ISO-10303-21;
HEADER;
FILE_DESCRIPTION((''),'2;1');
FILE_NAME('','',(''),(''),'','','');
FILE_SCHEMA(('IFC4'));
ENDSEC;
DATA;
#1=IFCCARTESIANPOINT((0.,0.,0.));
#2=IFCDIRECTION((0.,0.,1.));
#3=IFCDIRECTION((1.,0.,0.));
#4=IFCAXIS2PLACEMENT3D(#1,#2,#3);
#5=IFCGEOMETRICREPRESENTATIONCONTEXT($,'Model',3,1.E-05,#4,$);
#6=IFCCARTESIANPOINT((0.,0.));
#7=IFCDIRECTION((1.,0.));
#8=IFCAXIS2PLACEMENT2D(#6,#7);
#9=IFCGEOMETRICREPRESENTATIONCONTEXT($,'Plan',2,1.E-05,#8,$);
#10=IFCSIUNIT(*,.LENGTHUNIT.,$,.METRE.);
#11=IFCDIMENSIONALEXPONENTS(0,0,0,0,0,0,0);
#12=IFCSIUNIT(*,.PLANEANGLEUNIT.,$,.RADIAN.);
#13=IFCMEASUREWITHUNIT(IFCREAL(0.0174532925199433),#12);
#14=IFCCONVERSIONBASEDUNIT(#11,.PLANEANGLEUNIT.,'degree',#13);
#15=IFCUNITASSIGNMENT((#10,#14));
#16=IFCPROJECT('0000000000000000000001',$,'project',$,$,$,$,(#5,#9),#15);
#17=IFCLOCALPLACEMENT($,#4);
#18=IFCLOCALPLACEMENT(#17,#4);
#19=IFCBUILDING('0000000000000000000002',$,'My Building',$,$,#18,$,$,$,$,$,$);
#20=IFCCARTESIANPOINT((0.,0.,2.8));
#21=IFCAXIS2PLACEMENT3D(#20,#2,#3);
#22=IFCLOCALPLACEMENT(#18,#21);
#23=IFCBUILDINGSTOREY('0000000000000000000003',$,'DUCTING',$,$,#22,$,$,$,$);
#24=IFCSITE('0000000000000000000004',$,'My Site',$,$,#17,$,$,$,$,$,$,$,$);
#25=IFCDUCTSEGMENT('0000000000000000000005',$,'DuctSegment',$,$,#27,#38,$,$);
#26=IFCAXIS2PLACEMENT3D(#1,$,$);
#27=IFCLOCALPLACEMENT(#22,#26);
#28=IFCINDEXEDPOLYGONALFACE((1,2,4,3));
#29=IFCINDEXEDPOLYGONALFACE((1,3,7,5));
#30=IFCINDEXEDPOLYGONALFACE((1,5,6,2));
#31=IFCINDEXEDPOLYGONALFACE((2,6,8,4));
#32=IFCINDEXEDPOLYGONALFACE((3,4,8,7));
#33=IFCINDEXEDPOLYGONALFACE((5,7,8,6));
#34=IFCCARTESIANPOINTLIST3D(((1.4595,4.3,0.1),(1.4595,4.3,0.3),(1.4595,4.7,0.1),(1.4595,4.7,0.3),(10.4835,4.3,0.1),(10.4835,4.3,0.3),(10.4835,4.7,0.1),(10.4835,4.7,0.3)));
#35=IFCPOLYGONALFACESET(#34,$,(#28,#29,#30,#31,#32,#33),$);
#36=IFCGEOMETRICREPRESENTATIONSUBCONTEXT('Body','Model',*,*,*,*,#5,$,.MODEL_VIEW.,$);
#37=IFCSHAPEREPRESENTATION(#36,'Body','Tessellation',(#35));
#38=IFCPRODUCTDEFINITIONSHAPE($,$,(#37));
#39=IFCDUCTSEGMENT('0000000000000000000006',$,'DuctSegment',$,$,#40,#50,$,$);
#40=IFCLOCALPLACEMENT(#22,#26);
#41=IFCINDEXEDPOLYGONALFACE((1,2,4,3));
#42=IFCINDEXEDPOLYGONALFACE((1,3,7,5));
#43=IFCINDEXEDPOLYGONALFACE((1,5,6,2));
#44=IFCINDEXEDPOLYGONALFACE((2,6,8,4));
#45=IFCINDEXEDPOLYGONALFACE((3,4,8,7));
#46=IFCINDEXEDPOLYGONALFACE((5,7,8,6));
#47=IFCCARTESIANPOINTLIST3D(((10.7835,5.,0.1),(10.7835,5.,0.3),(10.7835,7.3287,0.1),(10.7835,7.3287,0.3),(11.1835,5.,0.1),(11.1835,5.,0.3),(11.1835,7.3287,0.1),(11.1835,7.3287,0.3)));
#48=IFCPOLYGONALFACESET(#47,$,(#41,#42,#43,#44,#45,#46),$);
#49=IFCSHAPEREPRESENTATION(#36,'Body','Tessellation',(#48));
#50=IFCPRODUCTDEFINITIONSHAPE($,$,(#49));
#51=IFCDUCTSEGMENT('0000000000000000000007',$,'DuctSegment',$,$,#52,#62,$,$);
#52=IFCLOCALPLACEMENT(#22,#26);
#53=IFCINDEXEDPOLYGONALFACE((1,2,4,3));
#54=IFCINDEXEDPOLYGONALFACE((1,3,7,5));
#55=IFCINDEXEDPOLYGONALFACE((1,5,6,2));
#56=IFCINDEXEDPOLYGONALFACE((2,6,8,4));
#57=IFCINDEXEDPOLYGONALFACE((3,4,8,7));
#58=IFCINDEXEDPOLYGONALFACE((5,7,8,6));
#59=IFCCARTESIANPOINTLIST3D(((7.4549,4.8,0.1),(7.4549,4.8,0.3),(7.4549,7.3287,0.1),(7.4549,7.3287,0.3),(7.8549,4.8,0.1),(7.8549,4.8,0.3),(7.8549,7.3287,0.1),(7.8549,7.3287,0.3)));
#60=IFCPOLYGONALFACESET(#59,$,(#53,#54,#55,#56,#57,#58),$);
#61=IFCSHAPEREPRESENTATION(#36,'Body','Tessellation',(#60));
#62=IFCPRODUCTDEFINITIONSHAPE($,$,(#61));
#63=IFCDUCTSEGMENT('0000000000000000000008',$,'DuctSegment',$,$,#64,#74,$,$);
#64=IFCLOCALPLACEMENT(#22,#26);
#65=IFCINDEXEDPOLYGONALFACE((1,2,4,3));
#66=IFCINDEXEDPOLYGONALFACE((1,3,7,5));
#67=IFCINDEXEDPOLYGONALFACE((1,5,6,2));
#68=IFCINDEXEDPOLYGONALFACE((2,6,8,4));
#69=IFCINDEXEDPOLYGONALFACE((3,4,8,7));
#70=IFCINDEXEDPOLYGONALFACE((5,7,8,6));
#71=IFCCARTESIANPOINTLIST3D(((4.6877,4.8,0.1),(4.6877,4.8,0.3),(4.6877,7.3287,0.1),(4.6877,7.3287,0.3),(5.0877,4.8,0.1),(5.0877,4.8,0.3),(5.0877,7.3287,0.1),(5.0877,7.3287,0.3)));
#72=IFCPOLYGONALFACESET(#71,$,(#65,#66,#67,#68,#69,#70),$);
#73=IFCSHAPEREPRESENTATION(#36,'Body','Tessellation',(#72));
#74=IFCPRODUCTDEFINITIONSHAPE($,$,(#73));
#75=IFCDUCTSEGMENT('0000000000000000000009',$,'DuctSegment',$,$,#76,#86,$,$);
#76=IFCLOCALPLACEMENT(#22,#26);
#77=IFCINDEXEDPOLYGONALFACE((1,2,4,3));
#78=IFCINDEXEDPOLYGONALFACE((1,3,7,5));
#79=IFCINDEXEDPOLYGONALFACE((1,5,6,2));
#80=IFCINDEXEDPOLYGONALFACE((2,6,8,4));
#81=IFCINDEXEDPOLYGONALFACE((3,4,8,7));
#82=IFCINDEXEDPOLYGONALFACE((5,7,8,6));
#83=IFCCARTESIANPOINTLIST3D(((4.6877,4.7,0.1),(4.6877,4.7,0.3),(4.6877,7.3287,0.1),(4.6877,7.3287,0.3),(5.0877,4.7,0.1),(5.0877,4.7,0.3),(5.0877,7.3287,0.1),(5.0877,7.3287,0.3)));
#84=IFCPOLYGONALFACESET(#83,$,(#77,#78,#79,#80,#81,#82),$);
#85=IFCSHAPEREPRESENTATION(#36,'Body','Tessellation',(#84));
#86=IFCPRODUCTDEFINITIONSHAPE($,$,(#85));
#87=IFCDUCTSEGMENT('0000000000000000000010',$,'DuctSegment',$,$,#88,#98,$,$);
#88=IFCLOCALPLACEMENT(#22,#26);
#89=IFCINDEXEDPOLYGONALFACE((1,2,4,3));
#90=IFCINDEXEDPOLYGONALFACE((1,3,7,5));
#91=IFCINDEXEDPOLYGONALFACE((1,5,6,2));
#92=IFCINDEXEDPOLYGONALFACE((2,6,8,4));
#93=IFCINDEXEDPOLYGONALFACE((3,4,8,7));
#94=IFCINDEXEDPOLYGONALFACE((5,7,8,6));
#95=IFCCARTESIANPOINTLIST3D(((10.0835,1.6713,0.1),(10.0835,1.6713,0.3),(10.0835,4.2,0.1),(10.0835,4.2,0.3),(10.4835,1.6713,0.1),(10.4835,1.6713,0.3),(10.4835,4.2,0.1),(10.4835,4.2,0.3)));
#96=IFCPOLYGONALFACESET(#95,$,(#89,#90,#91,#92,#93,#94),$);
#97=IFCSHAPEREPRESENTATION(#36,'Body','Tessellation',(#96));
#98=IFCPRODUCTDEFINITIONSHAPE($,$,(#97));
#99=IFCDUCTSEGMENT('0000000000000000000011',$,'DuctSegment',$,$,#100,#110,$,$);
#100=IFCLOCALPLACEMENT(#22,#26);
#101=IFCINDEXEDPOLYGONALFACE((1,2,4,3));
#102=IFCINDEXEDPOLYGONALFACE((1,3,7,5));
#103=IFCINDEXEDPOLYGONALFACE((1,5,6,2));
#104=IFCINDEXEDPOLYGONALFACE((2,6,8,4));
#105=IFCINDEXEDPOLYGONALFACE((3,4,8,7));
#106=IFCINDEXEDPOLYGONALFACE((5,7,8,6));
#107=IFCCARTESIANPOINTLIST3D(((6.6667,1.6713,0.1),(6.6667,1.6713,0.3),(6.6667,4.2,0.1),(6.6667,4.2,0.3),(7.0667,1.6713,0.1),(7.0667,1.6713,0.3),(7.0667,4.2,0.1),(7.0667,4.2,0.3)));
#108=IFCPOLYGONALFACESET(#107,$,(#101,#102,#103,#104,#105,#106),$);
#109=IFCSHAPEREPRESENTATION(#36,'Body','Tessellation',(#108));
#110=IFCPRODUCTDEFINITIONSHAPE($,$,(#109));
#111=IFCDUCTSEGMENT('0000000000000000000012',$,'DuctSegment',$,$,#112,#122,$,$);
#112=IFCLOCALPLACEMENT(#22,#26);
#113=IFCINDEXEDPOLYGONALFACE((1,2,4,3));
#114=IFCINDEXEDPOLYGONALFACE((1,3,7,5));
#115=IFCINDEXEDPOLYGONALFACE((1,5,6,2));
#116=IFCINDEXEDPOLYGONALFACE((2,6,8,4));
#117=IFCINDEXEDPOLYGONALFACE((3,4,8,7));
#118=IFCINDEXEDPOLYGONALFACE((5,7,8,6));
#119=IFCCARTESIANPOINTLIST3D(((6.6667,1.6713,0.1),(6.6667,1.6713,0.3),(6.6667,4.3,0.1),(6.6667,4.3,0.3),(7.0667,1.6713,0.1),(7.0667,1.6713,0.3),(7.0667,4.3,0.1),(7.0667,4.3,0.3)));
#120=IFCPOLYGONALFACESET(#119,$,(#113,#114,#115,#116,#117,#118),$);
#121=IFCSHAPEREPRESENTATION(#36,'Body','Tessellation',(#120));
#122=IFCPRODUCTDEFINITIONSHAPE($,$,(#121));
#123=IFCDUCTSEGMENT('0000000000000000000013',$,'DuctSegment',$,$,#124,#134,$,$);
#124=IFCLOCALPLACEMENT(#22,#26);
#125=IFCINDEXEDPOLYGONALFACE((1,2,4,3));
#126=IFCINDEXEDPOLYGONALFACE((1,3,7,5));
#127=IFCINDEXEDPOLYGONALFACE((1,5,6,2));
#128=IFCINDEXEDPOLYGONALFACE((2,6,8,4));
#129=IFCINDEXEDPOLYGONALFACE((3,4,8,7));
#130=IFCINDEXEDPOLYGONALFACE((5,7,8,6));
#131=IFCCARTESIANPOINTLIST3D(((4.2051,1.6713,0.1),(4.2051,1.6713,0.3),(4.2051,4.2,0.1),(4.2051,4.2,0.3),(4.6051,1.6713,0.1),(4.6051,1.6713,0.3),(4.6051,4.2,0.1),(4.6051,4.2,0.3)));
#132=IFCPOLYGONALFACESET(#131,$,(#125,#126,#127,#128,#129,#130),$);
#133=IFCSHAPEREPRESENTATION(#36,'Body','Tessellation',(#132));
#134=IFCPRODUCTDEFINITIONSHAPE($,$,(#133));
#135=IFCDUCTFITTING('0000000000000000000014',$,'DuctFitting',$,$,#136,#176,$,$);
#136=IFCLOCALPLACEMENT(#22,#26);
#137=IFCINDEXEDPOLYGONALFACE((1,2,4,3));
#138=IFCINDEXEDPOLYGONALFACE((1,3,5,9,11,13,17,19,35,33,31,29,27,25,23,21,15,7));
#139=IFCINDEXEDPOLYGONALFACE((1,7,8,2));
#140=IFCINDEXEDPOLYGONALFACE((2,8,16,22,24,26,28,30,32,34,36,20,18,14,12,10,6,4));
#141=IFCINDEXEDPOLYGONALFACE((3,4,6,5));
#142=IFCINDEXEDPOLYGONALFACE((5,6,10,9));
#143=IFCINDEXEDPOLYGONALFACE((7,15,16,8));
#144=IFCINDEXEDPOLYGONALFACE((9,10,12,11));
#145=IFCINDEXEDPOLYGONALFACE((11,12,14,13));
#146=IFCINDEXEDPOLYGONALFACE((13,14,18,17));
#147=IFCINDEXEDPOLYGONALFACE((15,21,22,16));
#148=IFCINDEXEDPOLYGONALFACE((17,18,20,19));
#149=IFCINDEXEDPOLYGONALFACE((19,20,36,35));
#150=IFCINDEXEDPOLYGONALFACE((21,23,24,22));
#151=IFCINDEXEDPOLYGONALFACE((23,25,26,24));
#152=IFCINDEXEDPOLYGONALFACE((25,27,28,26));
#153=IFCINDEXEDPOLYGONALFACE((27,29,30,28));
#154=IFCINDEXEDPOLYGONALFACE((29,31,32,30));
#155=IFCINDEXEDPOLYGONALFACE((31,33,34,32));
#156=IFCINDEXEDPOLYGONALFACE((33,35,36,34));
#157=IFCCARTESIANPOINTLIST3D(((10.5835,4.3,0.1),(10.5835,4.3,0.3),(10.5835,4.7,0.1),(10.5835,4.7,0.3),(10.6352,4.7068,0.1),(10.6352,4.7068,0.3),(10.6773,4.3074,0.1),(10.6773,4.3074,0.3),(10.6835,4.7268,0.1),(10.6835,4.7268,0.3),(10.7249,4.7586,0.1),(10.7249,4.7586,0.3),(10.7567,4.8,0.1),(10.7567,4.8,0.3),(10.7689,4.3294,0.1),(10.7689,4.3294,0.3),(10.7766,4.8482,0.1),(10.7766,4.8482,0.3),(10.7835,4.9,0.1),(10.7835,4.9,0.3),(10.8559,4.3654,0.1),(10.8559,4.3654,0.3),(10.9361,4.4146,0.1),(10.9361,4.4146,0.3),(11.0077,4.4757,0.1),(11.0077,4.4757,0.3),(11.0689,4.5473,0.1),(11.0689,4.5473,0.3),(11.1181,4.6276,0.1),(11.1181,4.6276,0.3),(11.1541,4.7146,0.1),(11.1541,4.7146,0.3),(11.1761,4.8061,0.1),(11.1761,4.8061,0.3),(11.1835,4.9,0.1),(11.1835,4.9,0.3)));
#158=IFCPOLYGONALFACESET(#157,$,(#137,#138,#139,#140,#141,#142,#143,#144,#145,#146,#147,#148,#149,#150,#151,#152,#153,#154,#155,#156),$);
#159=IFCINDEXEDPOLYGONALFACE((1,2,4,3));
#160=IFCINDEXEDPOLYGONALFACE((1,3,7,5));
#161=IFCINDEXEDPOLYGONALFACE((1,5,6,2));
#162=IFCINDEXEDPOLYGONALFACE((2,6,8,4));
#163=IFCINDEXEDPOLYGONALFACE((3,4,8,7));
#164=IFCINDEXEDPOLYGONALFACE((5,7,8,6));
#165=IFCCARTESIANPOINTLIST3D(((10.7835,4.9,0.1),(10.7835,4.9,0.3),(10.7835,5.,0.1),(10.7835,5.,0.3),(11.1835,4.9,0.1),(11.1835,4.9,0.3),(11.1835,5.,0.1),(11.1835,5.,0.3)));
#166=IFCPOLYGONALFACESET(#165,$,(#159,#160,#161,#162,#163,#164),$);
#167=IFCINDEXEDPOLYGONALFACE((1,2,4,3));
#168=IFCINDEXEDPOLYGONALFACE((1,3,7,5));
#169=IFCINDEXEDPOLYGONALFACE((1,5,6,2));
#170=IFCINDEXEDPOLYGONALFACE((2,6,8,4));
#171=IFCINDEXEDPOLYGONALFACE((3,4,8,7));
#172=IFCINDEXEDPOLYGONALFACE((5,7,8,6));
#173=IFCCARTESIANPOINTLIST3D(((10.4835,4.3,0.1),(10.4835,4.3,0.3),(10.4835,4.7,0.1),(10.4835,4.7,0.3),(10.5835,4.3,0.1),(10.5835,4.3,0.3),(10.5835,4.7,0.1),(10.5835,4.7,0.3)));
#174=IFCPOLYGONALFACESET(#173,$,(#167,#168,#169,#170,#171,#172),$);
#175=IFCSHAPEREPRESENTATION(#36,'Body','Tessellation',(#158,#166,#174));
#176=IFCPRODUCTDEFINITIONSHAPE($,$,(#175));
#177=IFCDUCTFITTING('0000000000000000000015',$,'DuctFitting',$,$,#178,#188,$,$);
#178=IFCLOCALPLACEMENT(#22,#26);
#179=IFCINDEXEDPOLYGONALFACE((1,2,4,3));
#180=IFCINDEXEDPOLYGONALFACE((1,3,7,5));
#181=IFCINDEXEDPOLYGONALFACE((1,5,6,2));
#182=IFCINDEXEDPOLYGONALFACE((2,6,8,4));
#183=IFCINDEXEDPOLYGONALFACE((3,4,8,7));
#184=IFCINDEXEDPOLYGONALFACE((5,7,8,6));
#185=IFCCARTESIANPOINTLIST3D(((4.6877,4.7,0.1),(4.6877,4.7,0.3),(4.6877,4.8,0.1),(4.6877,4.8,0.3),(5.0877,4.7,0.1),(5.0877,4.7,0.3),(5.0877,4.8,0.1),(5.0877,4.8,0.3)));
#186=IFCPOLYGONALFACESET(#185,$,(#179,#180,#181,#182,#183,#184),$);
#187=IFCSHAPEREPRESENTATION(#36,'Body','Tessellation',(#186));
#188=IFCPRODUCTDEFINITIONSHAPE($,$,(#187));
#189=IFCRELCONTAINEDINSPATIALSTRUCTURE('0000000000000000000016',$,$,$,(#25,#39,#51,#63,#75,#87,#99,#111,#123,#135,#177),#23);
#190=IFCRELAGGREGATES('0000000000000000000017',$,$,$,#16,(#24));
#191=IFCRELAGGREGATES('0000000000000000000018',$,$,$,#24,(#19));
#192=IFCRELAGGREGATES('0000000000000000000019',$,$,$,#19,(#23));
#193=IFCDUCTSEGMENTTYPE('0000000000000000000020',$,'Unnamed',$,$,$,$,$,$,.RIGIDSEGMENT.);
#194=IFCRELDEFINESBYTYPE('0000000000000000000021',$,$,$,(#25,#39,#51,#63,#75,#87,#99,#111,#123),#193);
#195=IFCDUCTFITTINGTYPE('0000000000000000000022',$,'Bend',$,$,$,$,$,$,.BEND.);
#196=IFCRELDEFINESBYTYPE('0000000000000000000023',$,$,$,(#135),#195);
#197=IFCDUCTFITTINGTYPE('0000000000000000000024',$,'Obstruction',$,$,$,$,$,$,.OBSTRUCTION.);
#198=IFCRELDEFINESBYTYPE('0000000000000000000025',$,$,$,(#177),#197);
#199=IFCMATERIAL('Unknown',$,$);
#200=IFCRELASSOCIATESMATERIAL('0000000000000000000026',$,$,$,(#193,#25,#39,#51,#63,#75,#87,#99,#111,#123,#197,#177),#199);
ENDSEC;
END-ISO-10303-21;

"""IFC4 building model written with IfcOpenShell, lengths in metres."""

from ifc_helpers import new_model, entity, si_unit, converted_unit, frame, origin_with_axes, origin_2d_with_axis, place, context, subcontext, project, spatial, line, arc, indexed_curve, rectangle, outline, extrude, source, transform, mapped, material, material_profile, profile_set, profile_usage, type_object, type_shapes, element, save


model = new_model("IFC4")

# Units and contexts
model_context = context("Model", 3, precision=1e-05, world=origin_with_axes())
plan_context = context("Plan", 2, precision=1e-05, world=origin_2d_with_axis())
body_context = subcontext(model_context, "Body", "Model", "MODEL_VIEW")
ifc_project = project(units=[si_unit("LENGTHUNIT", "METRE"), converted_unit("PLANEANGLEUNIT", "degree", entity("IfcReal", 0.0174532925199433), si_unit("PLANEANGLEUNIT", "RADIAN"), dimensions=[0, 0, 0, 0, 0, 0, 0])], contexts=[model_context, plan_context])

# Site, building, storey
site_placement = place(None, origin_with_axes())
site = spatial("IfcSite", under=ifc_project, at=site_placement, Name="My Site")
building_placement = place(site_placement, origin_with_axes())
building = spatial("IfcBuilding", under=site, at=building_placement, Name="My Building")
storey_placement = place(building_placement, frame((0.0, 0.0, 2.8), z_axis=(0.0, 0.0, 1.0), x_axis=(1.0, 0.0, 0.0)))
storey = spatial("IfcBuildingStorey", under=building, at=storey_placement, Name="DUCTING")

# Duct segments
ifc_material = material(Name="Unknown")
ifc_material_profile_1 = material_profile(ifc_material, rectangle(XDim=0.4, YDim=0.2))
ifc_profile_set_1 = profile_set([ifc_material_profile_1])
ifc_profile_usage_1 = profile_usage(ifc_profile_set_1, cardinal=5)
duct_segment_type = type_object("IfcDuctSegmentType", Name="Unnamed", PredefinedType="RIGIDSEGMENT", material=ifc_profile_set_1)
duct_segment_1_placement = place(storey_placement, frame((1.4595, 4.5, 0.2), z_axis=(1.0, 0.0, 0.0), x_axis=(0.0, 1.0, 0.0)))
element("IfcDuctSegment", 1, at=duct_segment_1_placement, inside=storey, type_object=duct_segment_type, material=ifc_profile_usage_1, Name="DuctSegment", context=body_context, shape_type="SweptSolid", body=[
    extrude(rectangle(XDim=0.4, YDim=0.2), origin_with_axes(), (0.0, 0.0, 1.0), 9.024),
])
ifc_profile_usage_2 = profile_usage(ifc_profile_set_1, cardinal=5)
duct_segment_2_placement = place(storey_placement, frame((10.9835, 5.0, 0.2), z_axis=(0.0, 1.0, 0.0), x_axis=(-1.0, 0.0, 0.0)))
element("IfcDuctSegment", 2, at=duct_segment_2_placement, inside=storey, type_object=duct_segment_type, material=ifc_profile_usage_2, Name="DuctSegment", context=body_context, shape_type="SweptSolid", body=[
    extrude(rectangle(XDim=0.4, YDim=0.2), origin_with_axes(), (0.0, 0.0, 1.0), 2.3287),
])
ifc_profile_usage_3 = profile_usage(ifc_profile_set_1, cardinal=5)
duct_segment_3_placement = place(storey_placement, frame((7.6549, 4.8, 0.2), z_axis=(0.0, 1.0, 0.0), x_axis=(-1.0, 0.0, 0.0)))
element("IfcDuctSegment", 3, at=duct_segment_3_placement, inside=storey, type_object=duct_segment_type, material=ifc_profile_usage_3, Name="DuctSegment", context=body_context, shape_type="SweptSolid", body=[
    extrude(rectangle(XDim=0.4, YDim=0.2), origin_with_axes(), (0.0, 0.0, 1.0), 2.5287),
])
ifc_profile_usage_4 = profile_usage(ifc_profile_set_1, cardinal=5)
duct_segment_4_placement = place(storey_placement, frame((4.8877, 4.8, 0.2), z_axis=(0.0, 1.0, 0.0), x_axis=(-1.0, 0.0, 0.0)))
element("IfcDuctSegment", 4, at=duct_segment_4_placement, inside=storey, type_object=duct_segment_type, material=ifc_profile_usage_4, Name="DuctSegment", context=body_context, shape_type="SweptSolid", body=[
    extrude(rectangle(XDim=0.4, YDim=0.2), origin_with_axes(), (0.0, 0.0, 1.0), 2.5287),
])
ifc_profile_usage_5 = profile_usage(ifc_profile_set_1, cardinal=5)
duct_segment_5_placement = place(storey_placement, frame((4.8877, 4.7, 0.2), z_axis=(0.0, 1.0, 0.0), x_axis=(-1.0, 0.0, 0.0)))
element("IfcDuctSegment", 5, at=duct_segment_5_placement, inside=storey, type_object=duct_segment_type, material=ifc_profile_usage_5, Name="DuctSegment", context=body_context, shape_type="SweptSolid", body=[
    extrude(rectangle(XDim=0.4, YDim=0.2), origin_with_axes(), (0.0, 0.0, 1.0), 2.6287),
])
ifc_profile_usage_6 = profile_usage(ifc_profile_set_1, cardinal=5)
duct_segment_6_placement = place(storey_placement, frame((10.2835, 4.2, 0.2), z_axis=(0.0, -1.0, 0.0), x_axis=(1.0, 0.0, 0.0)))
element("IfcDuctSegment", 6, at=duct_segment_6_placement, inside=storey, type_object=duct_segment_type, material=ifc_profile_usage_6, Name="DuctSegment", context=body_context, shape_type="SweptSolid", body=[
    extrude(rectangle(XDim=0.4, YDim=0.2), origin_with_axes(), (0.0, 0.0, 1.0), 2.5287),
])
ifc_profile_usage_7 = profile_usage(ifc_profile_set_1, cardinal=5)
duct_segment_7_placement = place(storey_placement, frame((6.8667, 4.2, 0.2), z_axis=(0.0, -1.0, 0.0), x_axis=(1.0, 0.0, 0.0)))
element("IfcDuctSegment", 7, at=duct_segment_7_placement, inside=storey, type_object=duct_segment_type, material=ifc_profile_usage_7, Name="DuctSegment", context=body_context, shape_type="SweptSolid", body=[
    extrude(rectangle(XDim=0.4, YDim=0.2), origin_with_axes(), (0.0, 0.0, 1.0), 2.5287),
])
ifc_profile_usage_8 = profile_usage(ifc_profile_set_1, cardinal=5)
duct_segment_8_placement = place(storey_placement, frame((6.8667, 4.3, 0.2), z_axis=(0.0, -1.0, 0.0), x_axis=(1.0, 0.0, 0.0)))
element("IfcDuctSegment", 8, at=duct_segment_8_placement, inside=storey, type_object=duct_segment_type, material=ifc_profile_usage_8, Name="DuctSegment", context=body_context, shape_type="SweptSolid", body=[
    extrude(rectangle(XDim=0.4, YDim=0.2), origin_with_axes(), (0.0, 0.0, 1.0), 2.6287),
])
ifc_profile_usage_9 = profile_usage(ifc_profile_set_1, cardinal=5)
duct_segment_9_placement = place(storey_placement, frame((4.4051, 4.2, 0.2), z_axis=(0.0, -1.0, 0.0), x_axis=(1.0, 0.0, 0.0)))
element("IfcDuctSegment", 9, at=duct_segment_9_placement, inside=storey, type_object=duct_segment_type, material=ifc_profile_usage_9, Name="DuctSegment", context=body_context, shape_type="SweptSolid", body=[
    extrude(rectangle(XDim=0.4, YDim=0.2), origin_with_axes(), (0.0, 0.0, 1.0), 2.5287),
])

# Duct fittings
duct_fitting_type_1 = type_object("IfcDuctFittingType", Name="Bend", PredefinedType="BEND")
shared_shape = source(origin_with_axes(), body_context, "Body", "SweptSolid", [
    extrude(outline(indexed_curve([(0.2, 0.0), (0.2586, -0.1414), (0.4, -0.2), (0.4, -0.6), (-0.0243, -0.4243), (-0.2, 0.0)], segments=[arc(1, 2, 3), line(3, 4), arc(4, 5, 6), line(6, 1)])), frame((0.0, -0.1, -0.1), z_axis=(0.0, -1.0, 0.0), x_axis=(1.0, 0.0, 0.0)), (0.0, 0.0, -1.0), 0.2),
    extrude(rectangle(XDim=0.4, YDim=0.2), origin_with_axes(), (0.0, 0.0, -1.0), 0.1),
    extrude(rectangle(XDim=0.4, YDim=0.2), frame((0.4, 0.0, -0.5), z_axis=(1.0, 0.0, 0.0), x_axis=(0.0, 0.0, 1.0)), (0.0, 0.0, 1.0), 0.1),
])
type_shapes(duct_fitting_type_1, [shared_shape])
duct_fitting_1_placement = place(storey_placement, frame((10.9835, 5.0, 0.2), z_axis=(0.0, 1.0, 0.0), x_axis=(-1.0, 0.0, 0.0)))
element("IfcDuctFitting", 10, at=duct_fitting_1_placement, inside=storey, type_object=duct_fitting_type_1, Name="DuctFitting", context=body_context, shape_type="MappedRepresentation", body=[
    mapped(shared_shape, transform((0.0, 0.0, 0.0), x_axis=(1.0, 0.0, 0.0), y_axis=(0.0, 1.0, 0.0), z_axis=(0.0, 0.0, 1.0), scale=1.0)),
])
ifc_material_profile_2 = material_profile(ifc_material, rectangle(XDim=0.4, YDim=0.2))
ifc_profile_set_2 = profile_set([ifc_material_profile_2])
ifc_profile_usage_10 = profile_usage(ifc_profile_set_2, cardinal=5)
duct_fitting_type_2 = type_object("IfcDuctFittingType", Name="Obstruction", PredefinedType="OBSTRUCTION", material=ifc_profile_set_2)
duct_fitting_2_placement = place(storey_placement, frame((4.8877, 4.7, 0.2), z_axis=(0.0, 1.0, 0.0), x_axis=(-1.0, 0.0, 0.0)))
element("IfcDuctFitting", 11, at=duct_fitting_2_placement, inside=storey, type_object=duct_fitting_type_2, material=ifc_profile_usage_10, Name="DuctFitting", context=body_context, shape_type="SweptSolid", body=[
    extrude(rectangle(XDim=0.4, YDim=0.2), origin_with_axes(), (0.0, 0.0, 1.0), 0.1),
])

save(model, "model.ifc")
